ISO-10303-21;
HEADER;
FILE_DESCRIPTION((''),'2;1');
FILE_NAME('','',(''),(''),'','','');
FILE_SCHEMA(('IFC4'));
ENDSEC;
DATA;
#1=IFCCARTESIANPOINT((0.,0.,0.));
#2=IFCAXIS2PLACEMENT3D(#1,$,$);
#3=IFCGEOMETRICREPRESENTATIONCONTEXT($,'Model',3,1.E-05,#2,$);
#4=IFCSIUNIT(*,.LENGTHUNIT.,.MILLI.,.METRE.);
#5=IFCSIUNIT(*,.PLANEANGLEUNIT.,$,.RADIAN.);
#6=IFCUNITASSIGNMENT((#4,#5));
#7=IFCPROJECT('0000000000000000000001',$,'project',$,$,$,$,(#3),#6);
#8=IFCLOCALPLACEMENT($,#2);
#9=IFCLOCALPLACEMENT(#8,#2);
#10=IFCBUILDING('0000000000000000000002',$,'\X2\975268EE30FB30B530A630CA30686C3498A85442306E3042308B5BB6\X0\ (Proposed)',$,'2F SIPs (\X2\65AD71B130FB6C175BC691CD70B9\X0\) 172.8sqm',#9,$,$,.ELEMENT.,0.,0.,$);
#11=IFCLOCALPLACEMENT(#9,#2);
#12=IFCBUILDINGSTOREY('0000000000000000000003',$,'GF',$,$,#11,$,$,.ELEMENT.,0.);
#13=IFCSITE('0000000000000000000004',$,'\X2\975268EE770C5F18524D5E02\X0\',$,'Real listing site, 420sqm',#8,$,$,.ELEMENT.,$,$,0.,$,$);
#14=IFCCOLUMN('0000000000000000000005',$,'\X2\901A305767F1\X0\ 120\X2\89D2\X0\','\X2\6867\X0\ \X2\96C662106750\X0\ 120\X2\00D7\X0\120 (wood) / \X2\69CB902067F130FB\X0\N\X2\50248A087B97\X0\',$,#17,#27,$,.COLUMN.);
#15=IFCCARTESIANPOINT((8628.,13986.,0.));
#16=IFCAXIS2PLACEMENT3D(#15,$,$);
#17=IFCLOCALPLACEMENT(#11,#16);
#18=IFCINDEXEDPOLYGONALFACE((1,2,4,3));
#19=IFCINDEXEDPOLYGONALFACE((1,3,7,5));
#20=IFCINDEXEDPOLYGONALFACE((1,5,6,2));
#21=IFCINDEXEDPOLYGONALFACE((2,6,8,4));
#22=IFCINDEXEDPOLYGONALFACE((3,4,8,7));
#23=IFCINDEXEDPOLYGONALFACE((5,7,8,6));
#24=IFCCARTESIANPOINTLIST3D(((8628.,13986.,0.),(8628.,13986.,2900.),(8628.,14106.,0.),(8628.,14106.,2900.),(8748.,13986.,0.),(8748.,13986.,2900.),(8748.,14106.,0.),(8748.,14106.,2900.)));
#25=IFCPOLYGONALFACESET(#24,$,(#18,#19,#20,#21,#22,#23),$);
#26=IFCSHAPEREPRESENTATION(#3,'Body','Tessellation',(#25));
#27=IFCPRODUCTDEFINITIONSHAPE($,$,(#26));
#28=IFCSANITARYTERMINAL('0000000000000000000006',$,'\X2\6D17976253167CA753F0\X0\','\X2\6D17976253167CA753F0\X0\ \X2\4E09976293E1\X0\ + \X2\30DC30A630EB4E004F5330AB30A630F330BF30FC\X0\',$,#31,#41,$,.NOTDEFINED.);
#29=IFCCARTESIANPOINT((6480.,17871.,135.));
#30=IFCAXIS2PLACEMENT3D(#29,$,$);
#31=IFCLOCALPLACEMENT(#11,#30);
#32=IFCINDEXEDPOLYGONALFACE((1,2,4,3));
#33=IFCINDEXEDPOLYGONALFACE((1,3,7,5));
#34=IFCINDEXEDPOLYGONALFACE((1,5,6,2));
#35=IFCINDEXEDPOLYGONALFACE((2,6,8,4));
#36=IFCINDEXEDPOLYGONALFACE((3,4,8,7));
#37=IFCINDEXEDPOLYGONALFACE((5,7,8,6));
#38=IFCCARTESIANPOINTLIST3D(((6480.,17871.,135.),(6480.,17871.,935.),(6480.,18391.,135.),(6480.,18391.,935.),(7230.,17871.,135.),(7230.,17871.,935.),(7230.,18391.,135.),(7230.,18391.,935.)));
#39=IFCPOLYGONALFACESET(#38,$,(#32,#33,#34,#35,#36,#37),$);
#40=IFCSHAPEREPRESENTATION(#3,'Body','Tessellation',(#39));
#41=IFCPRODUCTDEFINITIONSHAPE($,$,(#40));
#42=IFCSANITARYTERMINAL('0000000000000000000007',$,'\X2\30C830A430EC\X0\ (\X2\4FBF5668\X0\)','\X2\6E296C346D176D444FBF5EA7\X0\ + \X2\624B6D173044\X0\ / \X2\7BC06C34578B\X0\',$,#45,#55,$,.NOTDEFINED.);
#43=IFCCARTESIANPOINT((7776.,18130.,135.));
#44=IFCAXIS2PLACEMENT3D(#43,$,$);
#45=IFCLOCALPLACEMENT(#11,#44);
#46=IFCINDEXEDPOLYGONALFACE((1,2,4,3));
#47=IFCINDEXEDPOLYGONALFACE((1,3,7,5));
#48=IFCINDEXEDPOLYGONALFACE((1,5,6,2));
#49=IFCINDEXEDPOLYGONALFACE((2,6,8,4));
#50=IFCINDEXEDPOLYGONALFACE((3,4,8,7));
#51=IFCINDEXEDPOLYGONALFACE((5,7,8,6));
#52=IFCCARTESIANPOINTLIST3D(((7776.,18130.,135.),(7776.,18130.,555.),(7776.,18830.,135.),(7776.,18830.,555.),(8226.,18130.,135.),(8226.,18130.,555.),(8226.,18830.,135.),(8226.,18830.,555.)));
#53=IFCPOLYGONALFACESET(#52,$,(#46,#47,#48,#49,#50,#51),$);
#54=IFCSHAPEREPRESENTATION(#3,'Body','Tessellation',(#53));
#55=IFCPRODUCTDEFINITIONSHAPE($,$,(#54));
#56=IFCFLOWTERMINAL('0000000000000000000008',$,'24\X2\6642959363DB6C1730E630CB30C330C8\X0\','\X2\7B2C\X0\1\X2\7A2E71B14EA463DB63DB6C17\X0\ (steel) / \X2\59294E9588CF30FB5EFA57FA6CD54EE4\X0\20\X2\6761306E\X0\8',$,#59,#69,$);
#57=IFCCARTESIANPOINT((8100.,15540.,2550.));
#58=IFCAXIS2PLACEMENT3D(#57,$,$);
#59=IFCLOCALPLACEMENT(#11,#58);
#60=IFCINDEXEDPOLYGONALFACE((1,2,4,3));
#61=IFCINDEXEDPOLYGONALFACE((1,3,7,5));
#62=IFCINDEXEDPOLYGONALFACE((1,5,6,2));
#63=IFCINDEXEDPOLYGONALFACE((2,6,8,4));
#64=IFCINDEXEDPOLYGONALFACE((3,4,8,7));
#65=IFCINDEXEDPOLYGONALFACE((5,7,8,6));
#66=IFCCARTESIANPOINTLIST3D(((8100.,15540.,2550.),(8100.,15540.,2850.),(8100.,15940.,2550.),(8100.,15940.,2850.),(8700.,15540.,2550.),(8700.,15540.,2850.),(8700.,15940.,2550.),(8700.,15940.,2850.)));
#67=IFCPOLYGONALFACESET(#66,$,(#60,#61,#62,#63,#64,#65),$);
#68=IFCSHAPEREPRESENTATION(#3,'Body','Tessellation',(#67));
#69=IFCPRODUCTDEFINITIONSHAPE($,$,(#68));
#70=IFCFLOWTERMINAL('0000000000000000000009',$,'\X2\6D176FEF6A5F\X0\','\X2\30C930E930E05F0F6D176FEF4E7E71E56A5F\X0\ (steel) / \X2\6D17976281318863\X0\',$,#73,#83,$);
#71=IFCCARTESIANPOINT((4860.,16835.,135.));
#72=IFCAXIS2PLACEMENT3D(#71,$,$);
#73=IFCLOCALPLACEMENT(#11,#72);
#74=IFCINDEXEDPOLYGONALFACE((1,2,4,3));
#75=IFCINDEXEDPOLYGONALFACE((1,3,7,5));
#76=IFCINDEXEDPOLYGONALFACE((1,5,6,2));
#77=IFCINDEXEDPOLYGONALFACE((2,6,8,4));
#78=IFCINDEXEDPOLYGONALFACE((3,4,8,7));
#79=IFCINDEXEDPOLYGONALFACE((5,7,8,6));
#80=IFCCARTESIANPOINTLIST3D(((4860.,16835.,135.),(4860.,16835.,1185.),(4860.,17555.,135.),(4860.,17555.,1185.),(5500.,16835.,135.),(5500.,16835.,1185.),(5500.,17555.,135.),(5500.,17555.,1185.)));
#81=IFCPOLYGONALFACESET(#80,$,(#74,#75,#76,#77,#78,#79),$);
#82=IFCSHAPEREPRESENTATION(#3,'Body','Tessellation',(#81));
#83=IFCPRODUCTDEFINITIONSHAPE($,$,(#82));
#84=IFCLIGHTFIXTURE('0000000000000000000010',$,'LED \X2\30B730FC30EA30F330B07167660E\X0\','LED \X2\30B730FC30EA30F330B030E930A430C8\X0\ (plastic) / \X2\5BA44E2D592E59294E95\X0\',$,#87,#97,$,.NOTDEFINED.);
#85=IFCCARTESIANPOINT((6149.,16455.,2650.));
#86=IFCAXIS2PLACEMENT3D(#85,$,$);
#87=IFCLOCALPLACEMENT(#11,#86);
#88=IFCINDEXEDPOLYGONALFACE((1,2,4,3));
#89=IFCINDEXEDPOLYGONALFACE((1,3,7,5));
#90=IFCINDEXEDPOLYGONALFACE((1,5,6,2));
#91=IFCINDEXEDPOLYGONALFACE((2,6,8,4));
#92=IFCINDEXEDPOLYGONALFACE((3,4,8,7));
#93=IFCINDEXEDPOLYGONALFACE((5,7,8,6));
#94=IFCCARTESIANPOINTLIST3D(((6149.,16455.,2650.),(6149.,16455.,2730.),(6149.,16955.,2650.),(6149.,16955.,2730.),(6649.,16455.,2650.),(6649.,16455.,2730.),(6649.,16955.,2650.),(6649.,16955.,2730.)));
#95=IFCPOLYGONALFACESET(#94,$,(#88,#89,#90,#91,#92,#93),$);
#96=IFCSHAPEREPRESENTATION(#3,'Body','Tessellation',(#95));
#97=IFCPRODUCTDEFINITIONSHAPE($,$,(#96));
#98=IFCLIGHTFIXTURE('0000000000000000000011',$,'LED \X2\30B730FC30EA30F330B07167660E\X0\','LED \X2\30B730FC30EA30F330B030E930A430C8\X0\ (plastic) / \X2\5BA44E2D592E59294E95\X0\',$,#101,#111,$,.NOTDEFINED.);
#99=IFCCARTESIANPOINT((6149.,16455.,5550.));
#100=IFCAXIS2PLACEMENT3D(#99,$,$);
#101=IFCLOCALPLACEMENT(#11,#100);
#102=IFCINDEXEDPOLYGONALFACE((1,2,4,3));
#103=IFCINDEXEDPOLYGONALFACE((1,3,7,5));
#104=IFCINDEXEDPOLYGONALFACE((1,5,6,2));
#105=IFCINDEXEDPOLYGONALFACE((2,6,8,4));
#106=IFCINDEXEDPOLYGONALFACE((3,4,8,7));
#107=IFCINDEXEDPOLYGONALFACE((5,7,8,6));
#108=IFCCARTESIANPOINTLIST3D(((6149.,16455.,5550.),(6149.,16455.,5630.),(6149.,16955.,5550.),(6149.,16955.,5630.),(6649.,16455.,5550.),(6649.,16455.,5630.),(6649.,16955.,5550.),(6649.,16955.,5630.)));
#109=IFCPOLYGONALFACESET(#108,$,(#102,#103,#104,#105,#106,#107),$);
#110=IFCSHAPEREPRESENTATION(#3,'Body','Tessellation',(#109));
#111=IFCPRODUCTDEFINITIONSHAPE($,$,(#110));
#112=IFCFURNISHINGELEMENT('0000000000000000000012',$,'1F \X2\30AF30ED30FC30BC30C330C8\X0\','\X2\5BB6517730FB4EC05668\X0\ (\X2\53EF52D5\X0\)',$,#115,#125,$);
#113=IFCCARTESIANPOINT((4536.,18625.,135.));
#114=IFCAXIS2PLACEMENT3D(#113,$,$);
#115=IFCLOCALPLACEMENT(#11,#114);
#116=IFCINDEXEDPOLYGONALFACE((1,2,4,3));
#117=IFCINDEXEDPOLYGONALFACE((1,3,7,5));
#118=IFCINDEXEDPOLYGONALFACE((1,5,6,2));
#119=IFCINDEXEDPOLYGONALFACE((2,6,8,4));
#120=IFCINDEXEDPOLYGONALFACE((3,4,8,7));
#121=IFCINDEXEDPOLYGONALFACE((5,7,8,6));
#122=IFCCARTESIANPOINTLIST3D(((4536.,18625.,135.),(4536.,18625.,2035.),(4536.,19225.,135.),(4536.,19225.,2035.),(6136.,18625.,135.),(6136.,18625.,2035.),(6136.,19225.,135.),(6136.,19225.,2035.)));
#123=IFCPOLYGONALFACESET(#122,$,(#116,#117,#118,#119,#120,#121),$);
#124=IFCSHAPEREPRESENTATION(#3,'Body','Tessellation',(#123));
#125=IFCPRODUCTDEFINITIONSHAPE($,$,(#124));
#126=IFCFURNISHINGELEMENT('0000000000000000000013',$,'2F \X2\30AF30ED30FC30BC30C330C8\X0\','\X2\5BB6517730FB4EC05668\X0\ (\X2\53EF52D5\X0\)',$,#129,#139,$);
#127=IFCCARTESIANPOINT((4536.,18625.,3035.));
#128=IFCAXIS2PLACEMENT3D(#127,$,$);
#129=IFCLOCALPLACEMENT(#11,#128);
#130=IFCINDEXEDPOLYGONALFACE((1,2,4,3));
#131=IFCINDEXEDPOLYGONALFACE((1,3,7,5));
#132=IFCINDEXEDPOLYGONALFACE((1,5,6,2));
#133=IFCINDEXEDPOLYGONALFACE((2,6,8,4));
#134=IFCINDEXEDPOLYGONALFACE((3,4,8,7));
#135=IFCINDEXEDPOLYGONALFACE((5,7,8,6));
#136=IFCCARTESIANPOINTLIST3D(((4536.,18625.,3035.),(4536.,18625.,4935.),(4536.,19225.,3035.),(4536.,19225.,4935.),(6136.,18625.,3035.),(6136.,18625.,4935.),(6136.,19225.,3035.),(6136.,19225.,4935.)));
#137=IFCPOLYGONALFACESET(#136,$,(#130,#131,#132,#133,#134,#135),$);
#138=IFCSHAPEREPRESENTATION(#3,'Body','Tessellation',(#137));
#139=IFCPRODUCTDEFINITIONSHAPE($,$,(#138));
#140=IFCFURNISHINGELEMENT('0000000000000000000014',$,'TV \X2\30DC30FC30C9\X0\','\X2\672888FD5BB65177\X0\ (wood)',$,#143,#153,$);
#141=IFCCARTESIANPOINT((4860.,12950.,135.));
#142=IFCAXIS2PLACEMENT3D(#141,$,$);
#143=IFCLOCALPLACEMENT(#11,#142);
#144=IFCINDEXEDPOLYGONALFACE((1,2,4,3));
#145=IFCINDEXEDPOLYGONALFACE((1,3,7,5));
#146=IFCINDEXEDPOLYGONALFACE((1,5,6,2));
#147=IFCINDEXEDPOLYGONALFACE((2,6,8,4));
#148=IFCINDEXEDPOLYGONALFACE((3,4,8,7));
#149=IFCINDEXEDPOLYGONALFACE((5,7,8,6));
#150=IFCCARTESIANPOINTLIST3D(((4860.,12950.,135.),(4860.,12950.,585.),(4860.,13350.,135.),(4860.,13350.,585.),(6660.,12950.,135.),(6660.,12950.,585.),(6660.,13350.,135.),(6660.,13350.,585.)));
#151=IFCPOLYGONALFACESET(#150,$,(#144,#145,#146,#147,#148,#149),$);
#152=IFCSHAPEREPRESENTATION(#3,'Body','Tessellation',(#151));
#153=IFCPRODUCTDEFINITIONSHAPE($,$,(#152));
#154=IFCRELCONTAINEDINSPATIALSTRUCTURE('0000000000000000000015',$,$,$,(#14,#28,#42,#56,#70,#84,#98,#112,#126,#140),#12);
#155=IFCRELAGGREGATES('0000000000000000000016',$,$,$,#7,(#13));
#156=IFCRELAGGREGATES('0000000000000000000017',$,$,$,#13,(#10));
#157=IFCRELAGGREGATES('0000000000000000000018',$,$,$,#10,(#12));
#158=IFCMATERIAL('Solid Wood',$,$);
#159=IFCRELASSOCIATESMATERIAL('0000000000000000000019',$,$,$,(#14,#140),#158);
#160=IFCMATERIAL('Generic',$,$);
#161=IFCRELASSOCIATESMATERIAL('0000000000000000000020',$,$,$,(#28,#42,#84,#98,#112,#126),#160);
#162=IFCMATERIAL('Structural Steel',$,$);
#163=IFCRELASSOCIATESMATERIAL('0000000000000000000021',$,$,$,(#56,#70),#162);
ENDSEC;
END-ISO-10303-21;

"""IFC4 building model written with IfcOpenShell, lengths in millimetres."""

from ifc_helpers import new_model, si_unit, frame, frame_2d, origin, place, context, project, spatial, rectangle, extrude, material, element, save


model = new_model("IFC4")

# Units and contexts
model_context = context("Model", 3, precision=1e-05, world=origin())
ifc_project = project(units=[si_unit("LENGTHUNIT", "METRE", prefix="MILLI"), si_unit("PLANEANGLEUNIT", "RADIAN")], contexts=[model_context])

# Site, building, storey
site_placement = place(None, origin())
site = spatial("IfcSite", under=ifc_project, at=site_placement, Name="青森県弘前市", ObjectType="Real listing site, 420sqm", CompositionType="ELEMENT", RefElevation=0.0)
building_placement = place(site_placement, origin())
building = spatial("IfcBuilding", under=site, at=building_placement, Name="青森・サウナと水風呂のある家 (Proposed)", ObjectType="2F SIPs (断熱・気密重点) 172.8sqm", CompositionType="ELEMENT", ElevationOfRefHeight=0.0, ElevationOfTerrain=0.0)
storey_placement = place(building_placement, origin())
storey = spatial("IfcBuildingStorey", under=building, at=storey_placement, Name="GF", CompositionType="ELEMENT", Elevation=0.0)

# Column
ifc_material_1 = material(Name="Solid Wood")
column_1_placement = place(storey_placement, frame((8628.0, 13986.0, 0.0)))
element("IfcColumn", 1, at=column_1_placement, inside=storey, material=ifc_material_1, Name="通し柱 120角", Description="桧 集成材 120×120 (wood) / 構造柱・N値計算", PredefinedType="COLUMN", context=model_context, shape_type="SweptSolid", body=[
    extrude(rectangle(XDim=120.0, YDim=120.0, at=frame_2d((60.0, 60.0))), frame((8628.0, 13986.0, 0.0)), (0.0, 0.0, 1.0), 2900.0),
])

# Sanitary terminals
ifc_material_2 = material(Name="Generic")
sanitary_terminal_1_placement = place(storey_placement, frame((6480.0, 17871.0, 135.0)))
element("IfcSanitaryTerminal", 2, at=sanitary_terminal_1_placement, inside=storey, material=ifc_material_2, Name="洗面化粧台", Description="洗面化粧台 三面鏡 + ボウル一体カウンター", PredefinedType="NOTDEFINED", context=model_context, shape_type="SweptSolid", body=[
    extrude(rectangle(XDim=750.0, YDim=520.0, at=frame_2d((375.0, 260.0))), frame((6480.0, 17871.0, 135.0)), (0.0, 0.0, 1.0), 800.0),
])
sanitary_terminal_2_placement = place(storey_placement, frame((7776.0, 18130.0, 135.0)))
element("IfcSanitaryTerminal", 3, at=sanitary_terminal_2_placement, inside=storey, material=ifc_material_2, Name="トイレ (便器)", Description="温水洗浄便座 + 手洗い / 節水型", PredefinedType="NOTDEFINED", context=model_context, shape_type="SweptSolid", body=[
    extrude(rectangle(XDim=450.0, YDim=700.0, at=frame_2d((225.0, 350.0))), frame((7776.0, 18130.0, 135.0)), (0.0, 0.0, 1.0), 420.0),
])

# Flow terminals
ifc_material_3 = material(Name="Structural Steel")
flow_terminal_1_placement = place(storey_placement, frame((8100.0, 15540.0, 2550.0)))
element("IfcFlowTerminal", 4, at=flow_terminal_1_placement, inside=storey, material=ifc_material_3, Name="24時間換気ユニット", Description="第1種熱交換換気 (steel) / 天井裏・建基法令20条の8", context=model_context, shape_type="SweptSolid", body=[
    extrude(rectangle(XDim=600.0, YDim=400.0, at=frame_2d((300.0, 200.0))), frame((8100.0, 15540.0, 2550.0)), (0.0, 0.0, 1.0), 300.0),
])
flow_terminal_2_placement = place(storey_placement, frame((4860.0, 16835.0, 135.0)))
element("IfcFlowTerminal", 5, at=flow_terminal_2_placement, inside=storey, material=ifc_material_3, Name="洗濯機", Description="ドラム式洗濯乾燥機 (steel) / 洗面脱衣", context=model_context, shape_type="SweptSolid", body=[
    extrude(rectangle(XDim=640.0, YDim=720.0, at=frame_2d((320.0, 360.0))), frame((4860.0, 16835.0, 135.0)), (0.0, 0.0, 1.0), 1050.0),
])

# Light fixtures
light_fixture_1_placement = place(storey_placement, frame((6149.0, 16455.0, 2650.0)))
element("IfcLightFixture", 6, at=light_fixture_1_placement, inside=storey, material=ifc_material_2, Name="LED シーリング照明", Description="LED シーリングライト (plastic) / 室中央天井", PredefinedType="NOTDEFINED", context=model_context, shape_type="SweptSolid", body=[
    extrude(rectangle(XDim=500.0, YDim=500.0, at=frame_2d((250.0, 250.0))), frame((6149.0, 16455.0, 2650.0)), (0.0, 0.0, 1.0), 80.0),
])
light_fixture_2_placement = place(storey_placement, frame((6149.0, 16455.0, 5550.0)))
element("IfcLightFixture", 7, at=light_fixture_2_placement, inside=storey, material=ifc_material_2, Name="LED シーリング照明", Description="LED シーリングライト (plastic) / 室中央天井", PredefinedType="NOTDEFINED", context=model_context, shape_type="SweptSolid", body=[
    extrude(rectangle(XDim=500.0, YDim=500.0, at=frame_2d((250.0, 250.0))), frame((6149.0, 16455.0, 5550.0)), (0.0, 0.0, 1.0), 80.0),
])

# Furnishing elements
furnishing_1_placement = place(storey_placement, frame((4536.0, 18625.0, 135.0)))
element("IfcFurnishingElement", 8, at=furnishing_1_placement, inside=storey, material=ifc_material_2, Name="1F クローゼット", Description="家具・什器 (可動)", context=model_context, shape_type="SweptSolid", body=[
    extrude(rectangle(XDim=1600.0, YDim=600.0, at=frame_2d((800.0, 300.0))), frame((4536.0, 18625.0, 135.0)), (0.0, 0.0, 1.0), 1900.0),
])
furnishing_2_placement = place(storey_placement, frame((4536.0, 18625.0, 3035.0)))
element("IfcFurnishingElement", 9, at=furnishing_2_placement, inside=storey, material=ifc_material_2, Name="2F クローゼット", Description="家具・什器 (可動)", context=model_context, shape_type="SweptSolid", body=[
    extrude(rectangle(XDim=1600.0, YDim=600.0, at=frame_2d((800.0, 300.0))), frame((4536.0, 18625.0, 3035.0)), (0.0, 0.0, 1.0), 1900.0),
])
furnishing_3_placement = place(storey_placement, frame((4860.0, 12950.0, 135.0)))
element("IfcFurnishingElement", 10, at=furnishing_3_placement, inside=storey, material=ifc_material_1, Name="TV ボード", Description="木製家具 (wood)", context=model_context, shape_type="SweptSolid", body=[
    extrude(rectangle(XDim=1800.0, YDim=400.0, at=frame_2d((900.0, 200.0))), frame((4860.0, 12950.0, 135.0)), (0.0, 0.0, 1.0), 450.0),
])

save(model, "model.ifc")
